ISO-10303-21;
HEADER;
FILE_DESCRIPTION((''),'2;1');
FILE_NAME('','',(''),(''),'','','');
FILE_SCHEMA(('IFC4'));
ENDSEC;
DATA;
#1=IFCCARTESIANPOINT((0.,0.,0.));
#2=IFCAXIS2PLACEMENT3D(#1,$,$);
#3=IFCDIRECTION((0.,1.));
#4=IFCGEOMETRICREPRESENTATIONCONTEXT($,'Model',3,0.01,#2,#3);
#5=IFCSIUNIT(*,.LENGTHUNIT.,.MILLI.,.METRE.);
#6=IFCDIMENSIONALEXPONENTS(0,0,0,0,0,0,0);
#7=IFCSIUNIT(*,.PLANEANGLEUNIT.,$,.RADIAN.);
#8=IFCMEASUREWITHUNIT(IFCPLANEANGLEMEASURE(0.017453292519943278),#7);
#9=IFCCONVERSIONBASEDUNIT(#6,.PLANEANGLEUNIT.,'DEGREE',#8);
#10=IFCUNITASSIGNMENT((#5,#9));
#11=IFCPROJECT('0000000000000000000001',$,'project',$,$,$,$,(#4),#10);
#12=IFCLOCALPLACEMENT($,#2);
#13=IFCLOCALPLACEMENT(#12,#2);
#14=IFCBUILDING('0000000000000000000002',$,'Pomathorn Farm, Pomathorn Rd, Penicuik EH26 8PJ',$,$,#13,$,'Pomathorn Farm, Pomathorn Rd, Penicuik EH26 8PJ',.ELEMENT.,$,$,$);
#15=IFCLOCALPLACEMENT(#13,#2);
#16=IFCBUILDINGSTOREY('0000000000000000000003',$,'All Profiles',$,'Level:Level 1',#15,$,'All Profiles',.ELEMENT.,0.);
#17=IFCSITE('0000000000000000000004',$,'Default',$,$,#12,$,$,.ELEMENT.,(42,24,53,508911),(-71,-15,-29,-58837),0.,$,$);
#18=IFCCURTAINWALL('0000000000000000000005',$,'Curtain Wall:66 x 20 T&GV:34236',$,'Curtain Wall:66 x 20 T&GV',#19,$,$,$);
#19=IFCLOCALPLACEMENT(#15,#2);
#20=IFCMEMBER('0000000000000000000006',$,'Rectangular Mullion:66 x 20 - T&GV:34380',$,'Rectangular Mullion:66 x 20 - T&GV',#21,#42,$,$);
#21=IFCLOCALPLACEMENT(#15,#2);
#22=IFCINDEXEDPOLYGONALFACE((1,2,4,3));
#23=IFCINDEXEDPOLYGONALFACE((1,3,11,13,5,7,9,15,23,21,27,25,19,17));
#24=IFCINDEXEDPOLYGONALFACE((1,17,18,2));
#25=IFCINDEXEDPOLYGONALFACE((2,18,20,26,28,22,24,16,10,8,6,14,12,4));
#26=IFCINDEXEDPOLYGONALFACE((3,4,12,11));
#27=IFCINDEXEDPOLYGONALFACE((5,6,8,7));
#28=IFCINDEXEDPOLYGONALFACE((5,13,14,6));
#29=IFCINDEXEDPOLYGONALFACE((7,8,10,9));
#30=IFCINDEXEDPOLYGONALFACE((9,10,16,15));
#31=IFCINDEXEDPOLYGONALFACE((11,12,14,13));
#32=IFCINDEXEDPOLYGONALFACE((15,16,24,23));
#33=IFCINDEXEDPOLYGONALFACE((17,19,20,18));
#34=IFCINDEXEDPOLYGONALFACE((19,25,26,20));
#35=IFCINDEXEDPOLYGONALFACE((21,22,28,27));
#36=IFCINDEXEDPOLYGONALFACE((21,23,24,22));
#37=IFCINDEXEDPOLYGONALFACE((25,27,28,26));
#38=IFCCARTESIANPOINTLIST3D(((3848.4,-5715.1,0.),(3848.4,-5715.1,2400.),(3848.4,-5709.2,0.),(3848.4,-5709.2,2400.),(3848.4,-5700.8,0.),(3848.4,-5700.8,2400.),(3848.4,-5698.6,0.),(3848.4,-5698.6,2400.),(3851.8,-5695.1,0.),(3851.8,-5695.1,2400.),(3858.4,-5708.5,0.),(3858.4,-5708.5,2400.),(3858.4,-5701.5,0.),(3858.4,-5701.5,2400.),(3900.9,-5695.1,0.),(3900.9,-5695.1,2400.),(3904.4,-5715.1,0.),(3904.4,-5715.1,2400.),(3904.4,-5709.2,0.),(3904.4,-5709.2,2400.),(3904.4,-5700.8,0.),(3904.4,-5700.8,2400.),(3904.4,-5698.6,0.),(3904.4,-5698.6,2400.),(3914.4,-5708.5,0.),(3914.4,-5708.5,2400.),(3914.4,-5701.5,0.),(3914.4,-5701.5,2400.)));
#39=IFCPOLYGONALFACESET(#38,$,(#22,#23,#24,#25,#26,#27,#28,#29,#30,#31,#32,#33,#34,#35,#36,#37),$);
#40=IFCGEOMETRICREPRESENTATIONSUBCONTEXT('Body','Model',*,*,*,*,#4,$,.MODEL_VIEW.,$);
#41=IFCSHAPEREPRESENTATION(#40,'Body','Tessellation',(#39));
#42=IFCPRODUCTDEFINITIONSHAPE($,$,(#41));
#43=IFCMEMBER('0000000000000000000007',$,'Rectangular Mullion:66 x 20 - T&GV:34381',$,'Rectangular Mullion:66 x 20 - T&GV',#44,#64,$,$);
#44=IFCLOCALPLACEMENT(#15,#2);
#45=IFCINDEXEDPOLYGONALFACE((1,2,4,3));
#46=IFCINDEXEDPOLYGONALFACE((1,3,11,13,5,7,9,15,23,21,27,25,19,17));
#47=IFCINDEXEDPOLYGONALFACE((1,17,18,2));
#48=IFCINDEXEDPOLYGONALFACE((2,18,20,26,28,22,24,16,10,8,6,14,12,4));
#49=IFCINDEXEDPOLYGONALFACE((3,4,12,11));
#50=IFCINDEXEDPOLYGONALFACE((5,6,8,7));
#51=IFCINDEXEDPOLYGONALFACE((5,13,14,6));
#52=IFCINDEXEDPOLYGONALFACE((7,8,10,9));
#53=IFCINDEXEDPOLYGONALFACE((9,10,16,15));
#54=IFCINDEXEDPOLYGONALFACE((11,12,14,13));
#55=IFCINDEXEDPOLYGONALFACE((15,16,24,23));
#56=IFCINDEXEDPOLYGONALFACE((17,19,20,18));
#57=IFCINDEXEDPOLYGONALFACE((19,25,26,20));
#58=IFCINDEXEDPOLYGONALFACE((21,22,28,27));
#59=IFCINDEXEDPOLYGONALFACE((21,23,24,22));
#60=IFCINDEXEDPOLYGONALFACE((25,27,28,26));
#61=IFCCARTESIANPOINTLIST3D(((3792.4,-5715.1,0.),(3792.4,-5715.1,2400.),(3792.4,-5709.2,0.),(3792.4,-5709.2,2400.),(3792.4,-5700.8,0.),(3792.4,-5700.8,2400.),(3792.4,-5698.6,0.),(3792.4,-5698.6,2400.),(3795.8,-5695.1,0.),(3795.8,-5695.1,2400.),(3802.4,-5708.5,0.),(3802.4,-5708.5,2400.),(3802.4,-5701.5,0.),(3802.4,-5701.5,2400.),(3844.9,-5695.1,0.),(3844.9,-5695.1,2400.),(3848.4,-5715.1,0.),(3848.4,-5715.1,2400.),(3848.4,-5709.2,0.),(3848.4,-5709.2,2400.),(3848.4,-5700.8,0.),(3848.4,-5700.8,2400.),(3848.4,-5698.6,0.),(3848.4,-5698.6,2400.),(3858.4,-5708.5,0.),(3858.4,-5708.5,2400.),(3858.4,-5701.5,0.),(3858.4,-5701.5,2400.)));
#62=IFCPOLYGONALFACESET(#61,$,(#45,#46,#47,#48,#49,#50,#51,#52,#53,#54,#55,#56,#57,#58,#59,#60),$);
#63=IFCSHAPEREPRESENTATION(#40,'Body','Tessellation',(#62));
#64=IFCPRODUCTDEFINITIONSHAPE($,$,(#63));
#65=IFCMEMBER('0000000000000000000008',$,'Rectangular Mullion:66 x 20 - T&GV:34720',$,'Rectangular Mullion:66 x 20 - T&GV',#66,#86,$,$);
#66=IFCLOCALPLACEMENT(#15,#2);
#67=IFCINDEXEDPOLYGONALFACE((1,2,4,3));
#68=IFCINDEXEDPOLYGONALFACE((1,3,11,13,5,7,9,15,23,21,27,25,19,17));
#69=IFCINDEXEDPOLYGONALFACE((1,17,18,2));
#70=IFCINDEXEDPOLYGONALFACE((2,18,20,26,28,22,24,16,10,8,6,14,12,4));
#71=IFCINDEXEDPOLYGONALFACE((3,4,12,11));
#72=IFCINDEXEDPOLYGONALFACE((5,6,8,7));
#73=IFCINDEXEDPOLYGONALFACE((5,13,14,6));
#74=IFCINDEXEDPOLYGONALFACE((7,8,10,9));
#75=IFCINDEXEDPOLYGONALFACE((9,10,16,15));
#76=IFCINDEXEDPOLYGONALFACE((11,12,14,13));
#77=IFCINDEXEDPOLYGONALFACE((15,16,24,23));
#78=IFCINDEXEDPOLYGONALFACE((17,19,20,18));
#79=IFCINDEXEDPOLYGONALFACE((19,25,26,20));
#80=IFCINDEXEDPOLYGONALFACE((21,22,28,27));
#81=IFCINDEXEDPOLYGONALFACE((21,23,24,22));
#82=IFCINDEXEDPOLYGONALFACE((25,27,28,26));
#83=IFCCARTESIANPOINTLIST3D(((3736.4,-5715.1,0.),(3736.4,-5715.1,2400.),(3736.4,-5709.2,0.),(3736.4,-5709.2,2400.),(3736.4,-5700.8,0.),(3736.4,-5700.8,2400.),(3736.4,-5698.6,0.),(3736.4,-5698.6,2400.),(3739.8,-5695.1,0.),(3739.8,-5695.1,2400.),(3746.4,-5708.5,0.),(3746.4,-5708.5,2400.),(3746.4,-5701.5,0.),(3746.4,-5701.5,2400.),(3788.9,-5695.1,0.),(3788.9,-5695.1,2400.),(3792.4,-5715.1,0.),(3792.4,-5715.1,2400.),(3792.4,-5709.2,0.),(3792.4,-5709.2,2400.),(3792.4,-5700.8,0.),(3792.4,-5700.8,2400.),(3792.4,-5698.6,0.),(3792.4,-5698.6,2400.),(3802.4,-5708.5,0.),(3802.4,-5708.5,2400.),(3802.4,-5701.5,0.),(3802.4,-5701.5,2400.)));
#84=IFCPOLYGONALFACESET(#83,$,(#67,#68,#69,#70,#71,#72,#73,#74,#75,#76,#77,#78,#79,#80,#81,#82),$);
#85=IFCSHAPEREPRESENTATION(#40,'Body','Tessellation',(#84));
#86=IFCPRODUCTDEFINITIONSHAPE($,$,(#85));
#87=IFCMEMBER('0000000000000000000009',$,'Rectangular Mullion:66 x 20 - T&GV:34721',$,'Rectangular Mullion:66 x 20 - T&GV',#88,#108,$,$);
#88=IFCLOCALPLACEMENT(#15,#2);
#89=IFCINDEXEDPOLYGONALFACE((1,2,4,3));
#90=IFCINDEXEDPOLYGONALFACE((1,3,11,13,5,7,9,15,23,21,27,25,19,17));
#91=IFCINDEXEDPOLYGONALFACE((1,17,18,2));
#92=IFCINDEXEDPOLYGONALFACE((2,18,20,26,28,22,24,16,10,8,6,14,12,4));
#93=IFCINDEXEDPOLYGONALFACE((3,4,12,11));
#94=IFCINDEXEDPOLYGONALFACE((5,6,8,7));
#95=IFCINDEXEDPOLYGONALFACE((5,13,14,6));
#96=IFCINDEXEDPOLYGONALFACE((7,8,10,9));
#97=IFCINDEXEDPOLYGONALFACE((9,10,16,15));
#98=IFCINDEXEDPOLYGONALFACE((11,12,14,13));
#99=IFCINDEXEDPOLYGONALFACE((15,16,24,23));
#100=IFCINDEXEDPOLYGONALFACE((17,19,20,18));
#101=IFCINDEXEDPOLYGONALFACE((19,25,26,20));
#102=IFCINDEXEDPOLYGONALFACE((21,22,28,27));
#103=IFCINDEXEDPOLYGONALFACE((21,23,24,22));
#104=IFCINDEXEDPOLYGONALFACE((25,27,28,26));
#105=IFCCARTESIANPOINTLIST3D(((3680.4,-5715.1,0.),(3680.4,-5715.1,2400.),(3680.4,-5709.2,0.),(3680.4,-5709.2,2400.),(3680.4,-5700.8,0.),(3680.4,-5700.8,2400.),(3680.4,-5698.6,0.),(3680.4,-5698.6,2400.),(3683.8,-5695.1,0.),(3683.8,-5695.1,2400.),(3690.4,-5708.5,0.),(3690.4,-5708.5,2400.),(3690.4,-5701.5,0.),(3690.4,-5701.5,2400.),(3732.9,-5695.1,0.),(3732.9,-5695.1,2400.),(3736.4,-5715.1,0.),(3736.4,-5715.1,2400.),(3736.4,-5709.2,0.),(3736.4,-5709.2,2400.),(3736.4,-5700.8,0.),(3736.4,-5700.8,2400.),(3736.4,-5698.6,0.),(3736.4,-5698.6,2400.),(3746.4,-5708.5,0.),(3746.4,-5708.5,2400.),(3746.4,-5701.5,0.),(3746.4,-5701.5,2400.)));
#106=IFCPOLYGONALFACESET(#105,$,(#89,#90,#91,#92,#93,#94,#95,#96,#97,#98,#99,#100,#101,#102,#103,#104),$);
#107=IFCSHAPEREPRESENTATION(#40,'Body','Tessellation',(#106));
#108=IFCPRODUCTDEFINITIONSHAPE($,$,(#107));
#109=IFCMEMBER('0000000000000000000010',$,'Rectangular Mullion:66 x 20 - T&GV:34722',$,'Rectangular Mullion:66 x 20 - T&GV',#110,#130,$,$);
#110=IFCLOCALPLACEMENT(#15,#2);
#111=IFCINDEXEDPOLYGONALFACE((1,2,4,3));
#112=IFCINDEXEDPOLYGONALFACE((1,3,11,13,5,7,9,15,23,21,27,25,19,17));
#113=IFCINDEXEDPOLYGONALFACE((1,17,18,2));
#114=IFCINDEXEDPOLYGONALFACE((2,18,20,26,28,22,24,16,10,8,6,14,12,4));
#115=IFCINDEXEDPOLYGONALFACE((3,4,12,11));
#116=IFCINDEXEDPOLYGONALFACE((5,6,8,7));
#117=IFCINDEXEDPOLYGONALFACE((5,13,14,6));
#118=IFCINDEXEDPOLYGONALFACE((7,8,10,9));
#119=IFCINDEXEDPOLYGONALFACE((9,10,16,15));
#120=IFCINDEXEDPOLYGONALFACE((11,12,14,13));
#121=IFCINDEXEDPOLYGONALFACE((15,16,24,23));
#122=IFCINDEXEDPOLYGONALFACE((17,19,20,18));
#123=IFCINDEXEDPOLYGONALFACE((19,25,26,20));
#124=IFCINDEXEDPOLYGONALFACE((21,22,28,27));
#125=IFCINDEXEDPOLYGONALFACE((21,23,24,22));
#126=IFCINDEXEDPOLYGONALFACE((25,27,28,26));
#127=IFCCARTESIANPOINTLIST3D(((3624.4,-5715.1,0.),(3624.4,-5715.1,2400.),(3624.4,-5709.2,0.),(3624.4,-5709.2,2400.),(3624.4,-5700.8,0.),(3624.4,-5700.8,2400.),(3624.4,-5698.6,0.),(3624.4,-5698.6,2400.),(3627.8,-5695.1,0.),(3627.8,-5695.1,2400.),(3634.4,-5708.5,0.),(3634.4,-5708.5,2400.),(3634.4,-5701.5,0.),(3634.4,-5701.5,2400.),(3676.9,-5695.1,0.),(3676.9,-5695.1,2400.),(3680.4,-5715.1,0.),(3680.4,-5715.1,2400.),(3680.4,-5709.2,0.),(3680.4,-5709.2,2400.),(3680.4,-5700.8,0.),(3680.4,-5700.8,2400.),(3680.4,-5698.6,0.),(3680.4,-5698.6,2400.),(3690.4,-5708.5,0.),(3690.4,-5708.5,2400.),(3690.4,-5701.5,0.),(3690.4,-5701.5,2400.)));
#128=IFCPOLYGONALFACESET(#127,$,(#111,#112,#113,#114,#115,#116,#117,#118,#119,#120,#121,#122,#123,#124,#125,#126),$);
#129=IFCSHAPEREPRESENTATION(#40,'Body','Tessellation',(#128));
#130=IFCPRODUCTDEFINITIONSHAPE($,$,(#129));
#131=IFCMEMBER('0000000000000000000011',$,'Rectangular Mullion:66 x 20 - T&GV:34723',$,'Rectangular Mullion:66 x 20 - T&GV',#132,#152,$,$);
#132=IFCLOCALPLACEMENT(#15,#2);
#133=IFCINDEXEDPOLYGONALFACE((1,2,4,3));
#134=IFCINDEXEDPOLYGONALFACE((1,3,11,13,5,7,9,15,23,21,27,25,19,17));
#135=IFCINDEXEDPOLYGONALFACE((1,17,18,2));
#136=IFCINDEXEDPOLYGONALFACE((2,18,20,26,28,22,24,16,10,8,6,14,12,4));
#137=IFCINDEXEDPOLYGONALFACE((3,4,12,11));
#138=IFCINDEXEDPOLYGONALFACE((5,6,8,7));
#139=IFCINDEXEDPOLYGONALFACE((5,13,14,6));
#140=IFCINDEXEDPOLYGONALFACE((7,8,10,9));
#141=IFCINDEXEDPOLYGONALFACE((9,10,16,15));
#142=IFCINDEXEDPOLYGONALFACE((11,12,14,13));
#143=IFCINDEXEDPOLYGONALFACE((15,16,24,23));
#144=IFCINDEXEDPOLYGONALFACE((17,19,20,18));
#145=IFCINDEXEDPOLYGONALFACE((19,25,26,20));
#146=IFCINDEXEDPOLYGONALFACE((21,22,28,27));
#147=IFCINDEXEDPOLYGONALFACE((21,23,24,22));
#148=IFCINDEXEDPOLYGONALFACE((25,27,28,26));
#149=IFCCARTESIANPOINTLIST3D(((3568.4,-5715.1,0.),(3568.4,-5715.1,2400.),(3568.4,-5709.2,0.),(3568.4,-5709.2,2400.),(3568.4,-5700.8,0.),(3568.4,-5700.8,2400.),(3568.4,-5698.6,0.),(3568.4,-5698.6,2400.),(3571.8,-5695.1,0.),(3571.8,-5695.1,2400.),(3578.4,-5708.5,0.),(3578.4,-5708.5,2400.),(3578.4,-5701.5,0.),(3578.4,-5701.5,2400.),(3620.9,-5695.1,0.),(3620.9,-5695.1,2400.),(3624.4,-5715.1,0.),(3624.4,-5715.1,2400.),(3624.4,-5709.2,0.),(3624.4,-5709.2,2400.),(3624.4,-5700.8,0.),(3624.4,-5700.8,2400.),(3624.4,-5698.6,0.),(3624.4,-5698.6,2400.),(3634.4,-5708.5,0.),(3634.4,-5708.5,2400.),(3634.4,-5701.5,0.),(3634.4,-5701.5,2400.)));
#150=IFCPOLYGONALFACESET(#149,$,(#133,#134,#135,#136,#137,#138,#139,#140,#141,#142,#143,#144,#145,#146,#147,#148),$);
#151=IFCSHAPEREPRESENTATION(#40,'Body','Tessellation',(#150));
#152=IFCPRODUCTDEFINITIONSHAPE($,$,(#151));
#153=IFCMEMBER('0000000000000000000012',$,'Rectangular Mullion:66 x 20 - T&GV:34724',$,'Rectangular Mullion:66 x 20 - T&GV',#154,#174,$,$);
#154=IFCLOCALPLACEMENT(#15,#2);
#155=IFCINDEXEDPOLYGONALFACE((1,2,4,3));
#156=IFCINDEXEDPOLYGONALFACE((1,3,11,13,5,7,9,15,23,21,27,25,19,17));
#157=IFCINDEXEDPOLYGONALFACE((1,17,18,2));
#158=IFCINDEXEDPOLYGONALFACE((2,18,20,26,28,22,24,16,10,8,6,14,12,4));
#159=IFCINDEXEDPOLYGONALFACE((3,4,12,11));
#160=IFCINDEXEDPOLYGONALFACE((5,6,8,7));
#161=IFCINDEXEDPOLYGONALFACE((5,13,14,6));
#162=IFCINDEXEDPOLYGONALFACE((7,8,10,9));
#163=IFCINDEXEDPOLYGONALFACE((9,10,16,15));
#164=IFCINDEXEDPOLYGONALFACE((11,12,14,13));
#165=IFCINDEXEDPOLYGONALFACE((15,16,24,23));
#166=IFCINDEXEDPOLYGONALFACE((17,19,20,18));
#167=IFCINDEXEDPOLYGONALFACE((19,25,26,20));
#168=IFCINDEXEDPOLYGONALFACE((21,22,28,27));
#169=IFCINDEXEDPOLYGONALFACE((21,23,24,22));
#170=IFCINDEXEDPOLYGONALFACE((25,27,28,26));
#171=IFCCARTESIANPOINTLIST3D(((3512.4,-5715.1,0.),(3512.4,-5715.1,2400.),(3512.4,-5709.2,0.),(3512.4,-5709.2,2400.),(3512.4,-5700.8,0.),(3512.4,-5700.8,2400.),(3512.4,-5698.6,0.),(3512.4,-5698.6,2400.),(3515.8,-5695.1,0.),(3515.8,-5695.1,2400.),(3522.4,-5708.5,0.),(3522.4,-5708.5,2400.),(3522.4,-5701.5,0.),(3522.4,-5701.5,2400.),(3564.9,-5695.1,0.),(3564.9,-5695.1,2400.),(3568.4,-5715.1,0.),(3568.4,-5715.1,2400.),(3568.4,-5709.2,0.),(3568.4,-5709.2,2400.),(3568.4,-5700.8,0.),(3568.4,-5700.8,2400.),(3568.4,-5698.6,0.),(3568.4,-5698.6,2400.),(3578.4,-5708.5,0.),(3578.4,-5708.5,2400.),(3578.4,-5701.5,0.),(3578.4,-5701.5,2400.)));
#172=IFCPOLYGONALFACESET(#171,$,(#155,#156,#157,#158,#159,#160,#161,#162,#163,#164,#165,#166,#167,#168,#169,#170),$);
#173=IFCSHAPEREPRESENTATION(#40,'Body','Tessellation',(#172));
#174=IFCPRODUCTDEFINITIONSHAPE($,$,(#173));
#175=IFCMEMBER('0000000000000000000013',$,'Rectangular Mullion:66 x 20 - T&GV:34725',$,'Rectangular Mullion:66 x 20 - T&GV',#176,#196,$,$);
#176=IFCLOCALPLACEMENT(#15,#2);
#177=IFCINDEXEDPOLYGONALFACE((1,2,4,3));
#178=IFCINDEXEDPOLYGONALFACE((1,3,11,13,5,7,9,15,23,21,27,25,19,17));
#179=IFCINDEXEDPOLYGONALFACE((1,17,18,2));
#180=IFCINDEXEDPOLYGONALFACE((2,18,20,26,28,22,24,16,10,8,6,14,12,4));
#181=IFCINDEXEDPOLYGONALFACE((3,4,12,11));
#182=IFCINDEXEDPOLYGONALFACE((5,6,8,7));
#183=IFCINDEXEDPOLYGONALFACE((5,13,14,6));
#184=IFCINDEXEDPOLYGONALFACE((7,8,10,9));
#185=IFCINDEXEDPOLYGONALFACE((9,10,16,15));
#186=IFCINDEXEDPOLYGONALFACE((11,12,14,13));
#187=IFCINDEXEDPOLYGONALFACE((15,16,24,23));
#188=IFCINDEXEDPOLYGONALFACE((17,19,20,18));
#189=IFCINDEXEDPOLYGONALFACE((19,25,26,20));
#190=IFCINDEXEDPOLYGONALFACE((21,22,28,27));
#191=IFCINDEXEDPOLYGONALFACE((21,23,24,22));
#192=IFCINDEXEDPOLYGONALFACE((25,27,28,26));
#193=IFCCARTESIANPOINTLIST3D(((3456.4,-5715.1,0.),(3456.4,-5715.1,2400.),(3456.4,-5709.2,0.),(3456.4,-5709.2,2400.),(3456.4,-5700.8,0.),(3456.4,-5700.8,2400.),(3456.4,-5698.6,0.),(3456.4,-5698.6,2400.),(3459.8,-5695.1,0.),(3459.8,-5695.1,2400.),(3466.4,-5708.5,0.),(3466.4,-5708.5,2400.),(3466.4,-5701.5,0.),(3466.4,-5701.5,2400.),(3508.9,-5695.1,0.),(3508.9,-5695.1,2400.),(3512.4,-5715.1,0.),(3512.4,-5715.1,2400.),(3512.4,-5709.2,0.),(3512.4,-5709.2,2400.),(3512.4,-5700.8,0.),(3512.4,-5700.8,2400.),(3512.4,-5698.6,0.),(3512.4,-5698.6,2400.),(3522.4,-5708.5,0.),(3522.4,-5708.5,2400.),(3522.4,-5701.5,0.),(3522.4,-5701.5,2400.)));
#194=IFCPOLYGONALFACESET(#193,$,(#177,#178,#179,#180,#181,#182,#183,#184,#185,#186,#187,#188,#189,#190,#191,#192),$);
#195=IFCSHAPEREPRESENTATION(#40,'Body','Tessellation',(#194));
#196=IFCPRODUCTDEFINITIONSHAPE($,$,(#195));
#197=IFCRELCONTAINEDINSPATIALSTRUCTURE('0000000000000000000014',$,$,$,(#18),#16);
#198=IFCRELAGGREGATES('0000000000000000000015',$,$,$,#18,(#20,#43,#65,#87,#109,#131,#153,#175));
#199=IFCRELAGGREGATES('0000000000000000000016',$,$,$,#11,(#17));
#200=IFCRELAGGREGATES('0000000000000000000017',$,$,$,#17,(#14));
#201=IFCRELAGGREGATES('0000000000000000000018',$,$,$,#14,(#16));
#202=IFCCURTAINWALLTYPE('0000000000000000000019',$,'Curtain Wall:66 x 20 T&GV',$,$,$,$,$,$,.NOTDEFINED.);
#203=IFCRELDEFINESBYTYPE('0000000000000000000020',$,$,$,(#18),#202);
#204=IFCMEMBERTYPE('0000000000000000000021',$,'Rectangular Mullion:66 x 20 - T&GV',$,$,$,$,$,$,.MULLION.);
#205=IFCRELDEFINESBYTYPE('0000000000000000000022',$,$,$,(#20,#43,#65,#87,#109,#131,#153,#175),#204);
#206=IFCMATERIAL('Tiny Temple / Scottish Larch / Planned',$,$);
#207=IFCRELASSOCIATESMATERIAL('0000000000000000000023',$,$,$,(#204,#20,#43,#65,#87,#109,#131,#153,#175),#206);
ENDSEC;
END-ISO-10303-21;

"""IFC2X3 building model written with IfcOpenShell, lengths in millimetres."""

from ifc_helpers import new_model, entity, si_unit, converted_unit, direction, frame, origin, place, context, subcontext, project, spatial, polyline, outline, extrude, source, transform, mapped, material, type_object, type_shapes, element, aggregate, save


model = new_model("IFC2X3")

# Units and contexts
model_context = context("Model", 3, precision=0.01, world=origin(), true_north=direction((0.0, 1.0)))
body_context = subcontext(model_context, "Body", "Model", "MODEL_VIEW")
ifc_project = project(units=[si_unit("LENGTHUNIT", "METRE", prefix="MILLI"), converted_unit("PLANEANGLEUNIT", "DEGREE", entity("IfcPlaneAngleMeasure", 0.017453292519943278), si_unit("PLANEANGLEUNIT", "RADIAN"), dimensions=[0, 0, 0, 0, 0, 0, 0])], contexts=[model_context])

# Site, building, storey
site_placement = place(None, origin())
site = spatial("IfcSite", under=ifc_project, at=site_placement, Name="Default", CompositionType="ELEMENT", RefLatitude=(42, 24, 53, 508911), RefLongitude=(-71, -15, -29, -58837), RefElevation=0.0)
building_placement = place(site_placement, origin())
building = spatial("IfcBuilding", under=site, at=building_placement, Name="Pomathorn Farm, Pomathorn Rd, Penicuik EH26 8PJ", LongName="Pomathorn Farm, Pomathorn Rd, Penicuik EH26 8PJ", CompositionType="ELEMENT")
storey_placement = place(building_placement, origin())
storey = spatial("IfcBuildingStorey", under=building, at=storey_placement, Name="All Profiles", ObjectType="Level:Level 1", LongName="All Profiles", CompositionType="ELEMENT", Elevation=0.0)

# Curtain wall, members
curtain_wall_type_1 = type_object("IfcCurtainWallType", Name="Curtain Wall:66 x 20 T&GV", PredefinedType="NOTDEFINED")
curtain_wall_1_placement = place(storey_placement, origin())
curtain_wall_1 = element("IfcCurtainWall", 1, at=curtain_wall_1_placement, inside=storey, type_object=curtain_wall_type_1, Name="Curtain Wall:66 x 20 T&GV:34236", ObjectType="Curtain Wall:66 x 20 T&GV")
ifc_material = material(Name="Tiny Temple / Scottish Larch / Planned")
member_type_1 = type_object("IfcMemberType", Name="Rectangular Mullion:66 x 20 - T&GV", PredefinedType="MULLION", material=ifc_material)
shared_shape_1 = source(origin(), body_context, "Body", "SweptSolid", [
    extrude(outline(polyline([(-25.1, -11.0), (30.9, -11.0), (30.9, -5.1), (20.9, -4.4), (20.9, 2.6), (30.9, 3.3), (30.9, 5.5), (27.4, 9.0), (-21.7, 9.0), (-25.1, 5.5), (-25.1, 3.3), (-35.1, 2.6), (-35.1, -4.4), (-25.1, -5.1), (-25.1, -11.0)])), frame((-35.1, -11.0, -2400.0), z_axis=(0.0, 0.0, 1.0), x_axis=(-1.0, 0.0, 0.0)), (0.0, 0.0, 1.0), 2400.0),
])
type_shapes(member_type_1, [shared_shape_1])
member_1_placement = place(curtain_wall_1_placement, frame((3914.4, -5715.1, 0.0), z_axis=(0.0, 0.0, -1.0), x_axis=(1.0, 0.0, 0.0)))
member_1 = element("IfcMember", 2, at=member_1_placement, type_object=member_type_1, material=ifc_material, Name="Rectangular Mullion:66 x 20 - T&GV:34380", ObjectType="Rectangular Mullion:66 x 20 - T&GV", context=body_context, shape_type="MappedRepresentation", body=[
    mapped(shared_shape_1, transform((0.0, 0.0, 0.0), scale=1.0)),
])
member_2_placement = place(curtain_wall_1_placement, frame((3858.4, -5715.1, 0.0), z_axis=(0.0, 0.0, -1.0), x_axis=(1.0, 0.0, 0.0)))
member_2 = element("IfcMember", 3, at=member_2_placement, type_object=member_type_1, material=ifc_material, Name="Rectangular Mullion:66 x 20 - T&GV:34381", ObjectType="Rectangular Mullion:66 x 20 - T&GV", context=body_context, shape_type="MappedRepresentation", body=[
    mapped(shared_shape_1, transform((0.0, 0.0, 0.0), scale=1.0)),
])
member_3_placement = place(curtain_wall_1_placement, frame((3802.4, -5715.1, 0.0), z_axis=(0.0, 0.0, -1.0), x_axis=(1.0, 0.0, 0.0)))
member_3 = element("IfcMember", 4, at=member_3_placement, type_object=member_type_1, material=ifc_material, Name="Rectangular Mullion:66 x 20 - T&GV:34720", ObjectType="Rectangular Mullion:66 x 20 - T&GV", context=body_context, shape_type="MappedRepresentation", body=[
    mapped(shared_shape_1, transform((0.0, 0.0, 0.0), scale=1.0)),
])
member_4_placement = place(curtain_wall_1_placement, frame((3746.4, -5715.1, 0.0), z_axis=(0.0, 0.0, -1.0), x_axis=(1.0, 0.0, 0.0)))
member_4 = element("IfcMember", 5, at=member_4_placement, type_object=member_type_1, material=ifc_material, Name="Rectangular Mullion:66 x 20 - T&GV:34721", ObjectType="Rectangular Mullion:66 x 20 - T&GV", context=body_context, shape_type="MappedRepresentation", body=[
    mapped(shared_shape_1, transform((0.0, 0.0, 0.0), scale=1.0)),
])
member_5_placement = place(curtain_wall_1_placement, frame((3690.4, -5715.1, 0.0), z_axis=(0.0, 0.0, -1.0), x_axis=(1.0, 0.0, 0.0)))
member_5 = element("IfcMember", 6, at=member_5_placement, type_object=member_type_1, material=ifc_material, Name="Rectangular Mullion:66 x 20 - T&GV:34722", ObjectType="Rectangular Mullion:66 x 20 - T&GV", context=body_context, shape_type="MappedRepresentation", body=[
    mapped(shared_shape_1, transform((0.0, 0.0, 0.0), scale=1.0)),
])
member_6_placement = place(curtain_wall_1_placement, frame((3634.4, -5715.1, 0.0), z_axis=(0.0, 0.0, -1.0), x_axis=(1.0, 0.0, 0.0)))
member_6 = element("IfcMember", 7, at=member_6_placement, type_object=member_type_1, material=ifc_material, Name="Rectangular Mullion:66 x 20 - T&GV:34723", ObjectType="Rectangular Mullion:66 x 20 - T&GV", context=body_context, shape_type="MappedRepresentation", body=[
    mapped(shared_shape_1, transform((0.0, 0.0, 0.0), scale=1.0)),
])
member_7_placement = place(curtain_wall_1_placement, frame((3578.4, -5715.1, 0.0), z_axis=(0.0, 0.0, -1.0), x_axis=(1.0, 0.0, 0.0)))
member_7 = element("IfcMember", 8, at=member_7_placement, type_object=member_type_1, material=ifc_material, Name="Rectangular Mullion:66 x 20 - T&GV:34724", ObjectType="Rectangular Mullion:66 x 20 - T&GV", context=body_context, shape_type="MappedRepresentation", body=[
    mapped(shared_shape_1, transform((0.0, 0.0, 0.0), scale=1.0)),
])
member_8_placement = place(curtain_wall_1_placement, frame((3522.4, -5715.1, 0.0), z_axis=(0.0, 0.0, -1.0), x_axis=(1.0, 0.0, 0.0)))
member_8 = element("IfcMember", 9, at=member_8_placement, type_object=member_type_1, material=ifc_material, Name="Rectangular Mullion:66 x 20 - T&GV:34725", ObjectType="Rectangular Mullion:66 x 20 - T&GV", context=body_context, shape_type="MappedRepresentation", body=[
    mapped(shared_shape_1, transform((0.0, 0.0, 0.0), scale=1.0)),
])
aggregate(curtain_wall_1, [member_1, member_2, member_3, member_4, member_5, member_6, member_7, member_8])

save(model, "model.ifc")
